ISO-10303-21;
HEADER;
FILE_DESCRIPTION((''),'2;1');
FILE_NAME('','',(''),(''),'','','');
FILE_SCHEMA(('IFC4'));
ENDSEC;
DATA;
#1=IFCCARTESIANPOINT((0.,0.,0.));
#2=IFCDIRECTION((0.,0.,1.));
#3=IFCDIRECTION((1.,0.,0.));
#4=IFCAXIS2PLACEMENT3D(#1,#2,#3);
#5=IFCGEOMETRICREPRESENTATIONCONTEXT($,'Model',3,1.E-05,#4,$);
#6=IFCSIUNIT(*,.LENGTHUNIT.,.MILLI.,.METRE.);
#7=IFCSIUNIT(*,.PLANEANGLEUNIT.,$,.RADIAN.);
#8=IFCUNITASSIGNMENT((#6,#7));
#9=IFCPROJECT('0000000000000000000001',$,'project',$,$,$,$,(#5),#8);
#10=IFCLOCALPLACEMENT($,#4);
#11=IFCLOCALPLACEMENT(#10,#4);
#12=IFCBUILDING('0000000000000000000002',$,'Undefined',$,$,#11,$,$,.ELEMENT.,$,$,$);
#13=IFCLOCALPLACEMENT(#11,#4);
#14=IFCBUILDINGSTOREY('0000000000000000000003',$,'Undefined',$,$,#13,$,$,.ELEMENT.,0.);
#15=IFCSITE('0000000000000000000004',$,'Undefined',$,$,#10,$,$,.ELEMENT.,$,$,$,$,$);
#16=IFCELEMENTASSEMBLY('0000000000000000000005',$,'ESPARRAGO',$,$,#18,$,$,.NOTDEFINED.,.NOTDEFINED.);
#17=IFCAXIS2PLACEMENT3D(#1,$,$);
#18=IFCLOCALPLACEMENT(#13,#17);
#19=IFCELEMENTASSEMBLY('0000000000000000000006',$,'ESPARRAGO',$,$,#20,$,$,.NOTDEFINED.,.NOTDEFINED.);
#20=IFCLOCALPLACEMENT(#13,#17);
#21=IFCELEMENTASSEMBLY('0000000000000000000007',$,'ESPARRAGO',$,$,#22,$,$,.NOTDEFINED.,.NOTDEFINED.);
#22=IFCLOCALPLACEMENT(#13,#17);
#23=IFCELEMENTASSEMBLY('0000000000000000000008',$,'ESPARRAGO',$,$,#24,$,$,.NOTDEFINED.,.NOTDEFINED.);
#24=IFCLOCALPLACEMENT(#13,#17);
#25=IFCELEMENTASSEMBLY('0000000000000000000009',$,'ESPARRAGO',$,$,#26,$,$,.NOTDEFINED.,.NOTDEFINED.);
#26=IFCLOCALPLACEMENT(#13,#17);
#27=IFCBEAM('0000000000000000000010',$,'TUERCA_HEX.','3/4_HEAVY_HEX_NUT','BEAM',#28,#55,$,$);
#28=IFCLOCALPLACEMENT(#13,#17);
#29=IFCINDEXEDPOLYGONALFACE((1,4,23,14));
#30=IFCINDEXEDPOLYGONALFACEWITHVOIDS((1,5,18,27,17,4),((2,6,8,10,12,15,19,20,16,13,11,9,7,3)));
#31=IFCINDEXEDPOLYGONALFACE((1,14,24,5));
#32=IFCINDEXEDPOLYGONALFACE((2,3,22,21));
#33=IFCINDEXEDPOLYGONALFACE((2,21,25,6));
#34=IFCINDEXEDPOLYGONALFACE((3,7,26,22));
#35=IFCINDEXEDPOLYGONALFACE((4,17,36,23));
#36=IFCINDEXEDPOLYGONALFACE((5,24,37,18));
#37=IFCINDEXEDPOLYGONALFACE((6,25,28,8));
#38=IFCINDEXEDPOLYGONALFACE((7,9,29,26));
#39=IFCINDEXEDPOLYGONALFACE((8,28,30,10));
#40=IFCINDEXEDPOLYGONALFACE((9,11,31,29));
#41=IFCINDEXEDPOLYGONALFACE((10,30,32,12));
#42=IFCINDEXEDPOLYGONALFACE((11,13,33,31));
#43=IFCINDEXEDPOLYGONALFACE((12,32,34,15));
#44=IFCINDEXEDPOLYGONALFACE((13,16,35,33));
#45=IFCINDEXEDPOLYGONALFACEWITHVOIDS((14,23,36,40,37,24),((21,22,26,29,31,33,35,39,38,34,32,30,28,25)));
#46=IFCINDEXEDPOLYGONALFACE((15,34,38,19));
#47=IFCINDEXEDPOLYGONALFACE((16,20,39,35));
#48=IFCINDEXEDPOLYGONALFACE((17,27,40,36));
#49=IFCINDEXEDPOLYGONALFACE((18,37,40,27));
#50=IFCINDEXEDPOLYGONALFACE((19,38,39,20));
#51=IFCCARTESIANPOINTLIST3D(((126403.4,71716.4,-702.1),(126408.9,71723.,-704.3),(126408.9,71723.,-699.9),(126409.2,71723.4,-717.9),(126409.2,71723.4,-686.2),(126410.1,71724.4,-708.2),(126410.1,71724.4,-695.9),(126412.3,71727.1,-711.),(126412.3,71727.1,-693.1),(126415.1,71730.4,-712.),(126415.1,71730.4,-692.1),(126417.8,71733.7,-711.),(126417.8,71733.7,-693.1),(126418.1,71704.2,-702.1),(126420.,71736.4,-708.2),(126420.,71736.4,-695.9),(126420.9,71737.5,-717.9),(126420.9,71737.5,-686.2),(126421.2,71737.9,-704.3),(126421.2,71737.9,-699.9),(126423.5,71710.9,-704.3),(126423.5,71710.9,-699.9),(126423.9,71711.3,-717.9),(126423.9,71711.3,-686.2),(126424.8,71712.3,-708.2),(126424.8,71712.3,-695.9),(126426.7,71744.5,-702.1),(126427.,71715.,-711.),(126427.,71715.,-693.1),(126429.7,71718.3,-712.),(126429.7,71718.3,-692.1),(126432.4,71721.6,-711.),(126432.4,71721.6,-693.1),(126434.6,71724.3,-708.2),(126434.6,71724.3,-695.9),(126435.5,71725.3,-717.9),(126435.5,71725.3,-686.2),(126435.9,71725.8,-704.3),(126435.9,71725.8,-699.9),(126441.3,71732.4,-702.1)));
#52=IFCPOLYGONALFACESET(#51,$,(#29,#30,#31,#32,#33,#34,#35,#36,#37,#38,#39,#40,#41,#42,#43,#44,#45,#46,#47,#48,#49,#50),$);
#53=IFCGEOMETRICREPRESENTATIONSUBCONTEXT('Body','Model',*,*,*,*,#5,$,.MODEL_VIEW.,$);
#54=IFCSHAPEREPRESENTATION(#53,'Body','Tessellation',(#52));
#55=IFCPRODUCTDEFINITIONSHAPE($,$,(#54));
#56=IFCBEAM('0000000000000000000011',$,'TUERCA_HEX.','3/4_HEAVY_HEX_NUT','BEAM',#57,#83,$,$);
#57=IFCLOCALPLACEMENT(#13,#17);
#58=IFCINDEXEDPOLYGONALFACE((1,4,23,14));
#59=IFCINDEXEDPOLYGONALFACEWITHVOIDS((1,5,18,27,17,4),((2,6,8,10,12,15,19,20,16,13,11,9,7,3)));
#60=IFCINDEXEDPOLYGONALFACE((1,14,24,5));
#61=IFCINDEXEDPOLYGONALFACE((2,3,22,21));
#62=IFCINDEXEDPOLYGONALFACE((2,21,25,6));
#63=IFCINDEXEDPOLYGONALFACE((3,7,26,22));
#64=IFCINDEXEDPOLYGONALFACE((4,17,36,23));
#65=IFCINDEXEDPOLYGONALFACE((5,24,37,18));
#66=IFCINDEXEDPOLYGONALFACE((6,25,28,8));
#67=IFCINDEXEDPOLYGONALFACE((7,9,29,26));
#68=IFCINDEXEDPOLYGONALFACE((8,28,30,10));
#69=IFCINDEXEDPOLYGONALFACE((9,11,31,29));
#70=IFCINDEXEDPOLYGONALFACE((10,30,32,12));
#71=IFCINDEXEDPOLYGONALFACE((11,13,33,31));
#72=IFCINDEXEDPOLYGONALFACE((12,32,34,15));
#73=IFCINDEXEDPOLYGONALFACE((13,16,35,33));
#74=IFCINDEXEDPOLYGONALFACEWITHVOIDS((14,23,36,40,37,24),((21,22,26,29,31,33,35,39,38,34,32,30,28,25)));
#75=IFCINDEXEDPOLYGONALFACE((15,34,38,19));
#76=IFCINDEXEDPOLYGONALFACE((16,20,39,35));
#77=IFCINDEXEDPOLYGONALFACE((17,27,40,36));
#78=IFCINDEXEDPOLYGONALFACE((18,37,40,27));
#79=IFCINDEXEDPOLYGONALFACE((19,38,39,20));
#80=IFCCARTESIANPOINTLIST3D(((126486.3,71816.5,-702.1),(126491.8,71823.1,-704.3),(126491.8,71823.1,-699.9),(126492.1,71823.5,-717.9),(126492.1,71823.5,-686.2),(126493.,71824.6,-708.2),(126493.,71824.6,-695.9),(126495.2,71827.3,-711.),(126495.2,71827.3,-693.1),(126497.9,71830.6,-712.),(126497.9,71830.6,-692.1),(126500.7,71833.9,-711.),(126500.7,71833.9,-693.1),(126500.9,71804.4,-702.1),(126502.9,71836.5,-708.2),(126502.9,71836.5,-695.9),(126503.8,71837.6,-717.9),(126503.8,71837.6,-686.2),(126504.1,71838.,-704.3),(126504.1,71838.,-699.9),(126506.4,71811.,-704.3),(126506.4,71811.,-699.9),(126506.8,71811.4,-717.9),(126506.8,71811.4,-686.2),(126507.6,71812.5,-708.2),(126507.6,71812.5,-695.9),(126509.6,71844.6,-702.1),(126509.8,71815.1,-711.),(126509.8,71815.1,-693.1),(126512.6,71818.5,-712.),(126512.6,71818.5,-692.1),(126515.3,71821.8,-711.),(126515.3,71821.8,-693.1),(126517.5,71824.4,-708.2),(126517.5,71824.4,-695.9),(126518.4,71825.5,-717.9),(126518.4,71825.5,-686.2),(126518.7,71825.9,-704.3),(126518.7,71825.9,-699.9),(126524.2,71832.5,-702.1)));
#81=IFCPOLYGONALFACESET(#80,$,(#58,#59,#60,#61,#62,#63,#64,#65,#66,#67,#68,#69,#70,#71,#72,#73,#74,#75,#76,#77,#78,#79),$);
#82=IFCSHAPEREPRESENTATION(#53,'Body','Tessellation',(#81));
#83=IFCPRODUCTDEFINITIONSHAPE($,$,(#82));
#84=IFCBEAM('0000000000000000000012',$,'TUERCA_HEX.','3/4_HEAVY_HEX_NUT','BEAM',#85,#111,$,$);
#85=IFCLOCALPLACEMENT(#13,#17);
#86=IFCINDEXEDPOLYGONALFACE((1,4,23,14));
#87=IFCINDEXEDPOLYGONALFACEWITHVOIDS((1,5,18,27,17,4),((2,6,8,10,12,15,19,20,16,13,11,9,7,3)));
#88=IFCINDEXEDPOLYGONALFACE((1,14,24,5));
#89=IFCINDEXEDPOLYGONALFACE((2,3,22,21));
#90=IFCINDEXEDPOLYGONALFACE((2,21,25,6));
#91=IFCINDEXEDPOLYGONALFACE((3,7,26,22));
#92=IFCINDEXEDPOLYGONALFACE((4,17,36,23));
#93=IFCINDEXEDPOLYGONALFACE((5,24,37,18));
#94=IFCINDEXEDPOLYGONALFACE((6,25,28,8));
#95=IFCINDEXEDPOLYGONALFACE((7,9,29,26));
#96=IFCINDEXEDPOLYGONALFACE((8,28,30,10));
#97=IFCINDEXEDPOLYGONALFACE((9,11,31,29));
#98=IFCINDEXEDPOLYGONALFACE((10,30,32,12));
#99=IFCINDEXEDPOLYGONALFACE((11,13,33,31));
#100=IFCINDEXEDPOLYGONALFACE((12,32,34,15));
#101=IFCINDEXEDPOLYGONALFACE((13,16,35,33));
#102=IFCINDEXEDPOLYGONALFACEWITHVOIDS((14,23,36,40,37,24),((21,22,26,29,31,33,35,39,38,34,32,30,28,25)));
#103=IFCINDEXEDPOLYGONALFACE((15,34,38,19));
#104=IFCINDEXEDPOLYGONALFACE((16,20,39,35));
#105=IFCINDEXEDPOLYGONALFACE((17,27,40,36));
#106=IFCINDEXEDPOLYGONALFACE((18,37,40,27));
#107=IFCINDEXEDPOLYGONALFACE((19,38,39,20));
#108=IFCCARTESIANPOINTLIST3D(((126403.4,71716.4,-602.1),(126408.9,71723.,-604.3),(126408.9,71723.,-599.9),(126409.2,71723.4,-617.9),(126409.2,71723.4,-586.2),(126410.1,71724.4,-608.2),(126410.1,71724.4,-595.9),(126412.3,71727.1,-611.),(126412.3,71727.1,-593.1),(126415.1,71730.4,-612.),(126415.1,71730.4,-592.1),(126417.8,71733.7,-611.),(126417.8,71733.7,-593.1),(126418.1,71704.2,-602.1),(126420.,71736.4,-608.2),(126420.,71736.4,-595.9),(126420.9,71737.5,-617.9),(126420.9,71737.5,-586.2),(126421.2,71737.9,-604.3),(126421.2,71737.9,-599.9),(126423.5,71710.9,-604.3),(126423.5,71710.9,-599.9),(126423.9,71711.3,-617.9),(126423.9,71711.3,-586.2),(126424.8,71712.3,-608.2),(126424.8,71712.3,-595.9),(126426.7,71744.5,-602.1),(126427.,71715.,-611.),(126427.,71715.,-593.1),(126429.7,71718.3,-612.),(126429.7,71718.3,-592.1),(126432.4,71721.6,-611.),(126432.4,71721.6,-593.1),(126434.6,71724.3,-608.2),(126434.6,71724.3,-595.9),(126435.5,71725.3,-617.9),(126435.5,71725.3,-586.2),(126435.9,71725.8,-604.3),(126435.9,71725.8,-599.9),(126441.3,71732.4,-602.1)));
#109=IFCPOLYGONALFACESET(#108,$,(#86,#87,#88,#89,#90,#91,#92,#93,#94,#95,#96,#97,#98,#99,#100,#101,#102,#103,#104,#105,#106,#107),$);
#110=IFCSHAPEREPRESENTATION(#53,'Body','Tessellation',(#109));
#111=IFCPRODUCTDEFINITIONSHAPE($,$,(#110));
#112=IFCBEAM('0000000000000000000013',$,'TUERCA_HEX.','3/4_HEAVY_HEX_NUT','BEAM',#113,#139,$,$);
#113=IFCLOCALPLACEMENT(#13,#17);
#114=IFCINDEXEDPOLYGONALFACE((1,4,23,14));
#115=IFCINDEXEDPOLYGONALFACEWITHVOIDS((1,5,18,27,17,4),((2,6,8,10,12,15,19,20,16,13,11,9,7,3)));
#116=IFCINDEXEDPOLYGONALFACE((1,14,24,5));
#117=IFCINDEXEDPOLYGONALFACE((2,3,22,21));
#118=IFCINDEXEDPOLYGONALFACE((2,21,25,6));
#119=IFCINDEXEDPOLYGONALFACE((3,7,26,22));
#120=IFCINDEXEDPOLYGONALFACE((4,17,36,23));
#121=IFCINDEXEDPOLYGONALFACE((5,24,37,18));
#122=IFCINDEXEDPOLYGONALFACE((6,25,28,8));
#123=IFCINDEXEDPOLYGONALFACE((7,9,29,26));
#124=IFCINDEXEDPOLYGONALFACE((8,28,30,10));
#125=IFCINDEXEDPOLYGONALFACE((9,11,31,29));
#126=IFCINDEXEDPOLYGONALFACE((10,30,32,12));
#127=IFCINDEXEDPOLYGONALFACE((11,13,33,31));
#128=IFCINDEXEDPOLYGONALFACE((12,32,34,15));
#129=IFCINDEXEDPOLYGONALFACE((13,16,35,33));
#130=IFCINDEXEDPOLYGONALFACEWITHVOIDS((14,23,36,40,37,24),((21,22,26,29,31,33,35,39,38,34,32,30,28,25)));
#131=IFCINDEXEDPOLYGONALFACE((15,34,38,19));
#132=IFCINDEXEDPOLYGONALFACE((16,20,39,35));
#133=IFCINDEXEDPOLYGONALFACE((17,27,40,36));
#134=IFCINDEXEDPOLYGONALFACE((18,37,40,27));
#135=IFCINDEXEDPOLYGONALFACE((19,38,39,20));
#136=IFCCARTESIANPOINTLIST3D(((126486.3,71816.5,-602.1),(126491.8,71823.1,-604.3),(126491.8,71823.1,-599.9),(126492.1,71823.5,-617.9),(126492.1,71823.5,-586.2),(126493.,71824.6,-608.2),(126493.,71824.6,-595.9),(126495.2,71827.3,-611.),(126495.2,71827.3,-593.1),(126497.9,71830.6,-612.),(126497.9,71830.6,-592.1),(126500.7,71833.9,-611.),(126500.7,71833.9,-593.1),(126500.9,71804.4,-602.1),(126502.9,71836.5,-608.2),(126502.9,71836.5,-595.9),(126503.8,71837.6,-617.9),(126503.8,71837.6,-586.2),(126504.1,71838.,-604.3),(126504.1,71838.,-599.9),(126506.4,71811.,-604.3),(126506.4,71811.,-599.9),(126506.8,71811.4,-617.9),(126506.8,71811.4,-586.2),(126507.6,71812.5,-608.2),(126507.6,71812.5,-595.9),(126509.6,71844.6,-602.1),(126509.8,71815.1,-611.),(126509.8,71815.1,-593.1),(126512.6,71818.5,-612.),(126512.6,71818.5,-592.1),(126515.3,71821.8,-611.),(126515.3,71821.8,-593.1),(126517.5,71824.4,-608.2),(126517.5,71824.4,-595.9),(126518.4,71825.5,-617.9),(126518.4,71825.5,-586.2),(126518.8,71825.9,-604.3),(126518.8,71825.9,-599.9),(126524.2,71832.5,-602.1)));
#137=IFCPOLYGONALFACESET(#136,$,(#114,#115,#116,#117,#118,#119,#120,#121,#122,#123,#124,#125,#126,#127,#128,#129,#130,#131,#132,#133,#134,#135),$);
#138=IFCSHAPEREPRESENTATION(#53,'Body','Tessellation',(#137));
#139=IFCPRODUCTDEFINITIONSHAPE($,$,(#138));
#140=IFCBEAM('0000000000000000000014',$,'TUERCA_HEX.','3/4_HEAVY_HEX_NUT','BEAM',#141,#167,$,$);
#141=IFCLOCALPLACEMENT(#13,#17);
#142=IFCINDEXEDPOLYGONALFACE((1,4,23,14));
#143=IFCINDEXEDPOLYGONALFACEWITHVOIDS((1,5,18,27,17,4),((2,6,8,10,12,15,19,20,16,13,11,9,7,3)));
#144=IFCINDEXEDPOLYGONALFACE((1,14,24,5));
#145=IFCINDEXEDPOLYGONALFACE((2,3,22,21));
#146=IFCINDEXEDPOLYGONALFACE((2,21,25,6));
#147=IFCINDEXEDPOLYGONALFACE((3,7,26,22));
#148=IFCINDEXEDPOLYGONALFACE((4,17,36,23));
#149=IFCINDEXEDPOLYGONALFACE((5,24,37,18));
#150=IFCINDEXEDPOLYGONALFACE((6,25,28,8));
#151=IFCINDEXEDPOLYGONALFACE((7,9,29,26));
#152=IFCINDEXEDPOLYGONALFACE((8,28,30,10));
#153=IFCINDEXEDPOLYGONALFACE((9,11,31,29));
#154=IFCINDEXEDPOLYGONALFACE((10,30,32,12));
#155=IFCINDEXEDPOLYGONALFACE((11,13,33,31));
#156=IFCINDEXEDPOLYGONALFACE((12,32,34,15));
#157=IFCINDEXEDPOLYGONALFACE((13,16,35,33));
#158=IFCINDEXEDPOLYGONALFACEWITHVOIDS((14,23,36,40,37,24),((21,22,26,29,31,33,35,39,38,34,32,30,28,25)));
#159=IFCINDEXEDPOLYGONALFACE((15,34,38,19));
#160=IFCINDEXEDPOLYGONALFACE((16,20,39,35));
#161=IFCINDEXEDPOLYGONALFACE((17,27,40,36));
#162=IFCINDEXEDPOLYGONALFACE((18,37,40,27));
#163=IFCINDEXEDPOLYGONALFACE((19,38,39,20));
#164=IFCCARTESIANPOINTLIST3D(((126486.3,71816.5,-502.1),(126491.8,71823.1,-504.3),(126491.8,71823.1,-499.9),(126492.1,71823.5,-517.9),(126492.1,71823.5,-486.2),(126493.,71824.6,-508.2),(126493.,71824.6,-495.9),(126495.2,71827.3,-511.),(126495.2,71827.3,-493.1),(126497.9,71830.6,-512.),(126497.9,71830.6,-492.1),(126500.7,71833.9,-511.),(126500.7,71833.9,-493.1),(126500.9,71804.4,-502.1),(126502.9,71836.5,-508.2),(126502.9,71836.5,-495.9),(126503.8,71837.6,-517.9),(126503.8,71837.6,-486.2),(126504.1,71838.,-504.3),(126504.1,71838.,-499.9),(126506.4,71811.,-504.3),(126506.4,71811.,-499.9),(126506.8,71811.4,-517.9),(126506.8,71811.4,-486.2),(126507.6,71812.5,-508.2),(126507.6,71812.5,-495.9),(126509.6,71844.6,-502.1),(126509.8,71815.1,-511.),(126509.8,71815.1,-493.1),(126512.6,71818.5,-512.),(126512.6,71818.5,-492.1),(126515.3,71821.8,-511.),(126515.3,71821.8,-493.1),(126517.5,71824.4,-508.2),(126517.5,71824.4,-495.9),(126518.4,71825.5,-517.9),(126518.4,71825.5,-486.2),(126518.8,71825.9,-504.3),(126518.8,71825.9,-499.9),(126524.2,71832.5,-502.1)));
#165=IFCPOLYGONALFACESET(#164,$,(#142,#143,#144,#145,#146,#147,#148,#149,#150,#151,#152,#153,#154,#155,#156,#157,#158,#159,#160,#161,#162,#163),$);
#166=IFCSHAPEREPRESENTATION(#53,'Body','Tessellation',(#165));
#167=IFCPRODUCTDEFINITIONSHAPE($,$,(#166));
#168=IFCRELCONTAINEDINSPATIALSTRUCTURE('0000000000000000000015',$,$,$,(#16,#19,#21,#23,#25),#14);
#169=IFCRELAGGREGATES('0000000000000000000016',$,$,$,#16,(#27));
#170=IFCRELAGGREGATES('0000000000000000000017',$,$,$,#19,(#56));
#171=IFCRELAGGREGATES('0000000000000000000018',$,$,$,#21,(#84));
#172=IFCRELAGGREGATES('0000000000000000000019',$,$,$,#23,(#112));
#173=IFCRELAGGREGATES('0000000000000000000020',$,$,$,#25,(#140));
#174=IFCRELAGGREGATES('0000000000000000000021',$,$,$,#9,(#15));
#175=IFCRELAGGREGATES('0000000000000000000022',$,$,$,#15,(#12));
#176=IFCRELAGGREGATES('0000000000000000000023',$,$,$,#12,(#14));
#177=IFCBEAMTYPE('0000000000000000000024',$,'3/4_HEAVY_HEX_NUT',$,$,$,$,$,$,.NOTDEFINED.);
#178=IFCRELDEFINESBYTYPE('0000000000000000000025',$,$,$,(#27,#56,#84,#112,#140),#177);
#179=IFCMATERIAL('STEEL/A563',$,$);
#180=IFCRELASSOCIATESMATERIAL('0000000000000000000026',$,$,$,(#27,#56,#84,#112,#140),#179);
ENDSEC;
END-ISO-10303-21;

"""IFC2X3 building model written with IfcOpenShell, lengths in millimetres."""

from ifc_helpers import new_model, si_unit, frame, origin_with_axes, place, context, subcontext, project, spatial, polyline, outline, extrude, material, type_object, element, aggregate, save


model = new_model("IFC2X3")

# Units and contexts
model_context = context("Model", 3, precision=1e-05, world=origin_with_axes())
body_context = subcontext(model_context, "Body", "Model", "MODEL_VIEW")
ifc_project = project(units=[si_unit("LENGTHUNIT", "METRE", prefix="MILLI"), si_unit("PLANEANGLEUNIT", "RADIAN")], contexts=[model_context])

# Site, building, storey
site_placement = place(None, origin_with_axes())
site = spatial("IfcSite", under=ifc_project, at=site_placement, Name="Undefined", CompositionType="ELEMENT")
building_placement = place(site_placement, origin_with_axes())
building = spatial("IfcBuilding", under=site, at=building_placement, Name="Undefined", CompositionType="ELEMENT")
storey_placement = place(building_placement, origin_with_axes())
storey = spatial("IfcBuildingStorey", under=building, at=storey_placement, Name="Undefined", CompositionType="ELEMENT", Elevation=0.0)

# Element assemblies
assembly_1_placement = place(storey_placement, origin_with_axes())
assembly_1 = element("IfcElementAssembly", 1, at=assembly_1_placement, inside=storey, Name="ESPARRAGO", AssemblyPlace="NOTDEFINED", PredefinedType="NOTDEFINED")
assembly_2_placement = place(storey_placement, origin_with_axes())
assembly_2 = element("IfcElementAssembly", 2, at=assembly_2_placement, inside=storey, Name="ESPARRAGO", AssemblyPlace="NOTDEFINED", PredefinedType="NOTDEFINED")
assembly_3_placement = place(storey_placement, origin_with_axes())
assembly_3 = element("IfcElementAssembly", 3, at=assembly_3_placement, inside=storey, Name="ESPARRAGO", AssemblyPlace="NOTDEFINED", PredefinedType="NOTDEFINED")
assembly_4_placement = place(storey_placement, origin_with_axes())
assembly_4 = element("IfcElementAssembly", 4, at=assembly_4_placement, inside=storey, Name="ESPARRAGO", AssemblyPlace="NOTDEFINED", PredefinedType="NOTDEFINED")
assembly_5_placement = place(storey_placement, origin_with_axes())
assembly_5 = element("IfcElementAssembly", 5, at=assembly_5_placement, inside=storey, Name="ESPARRAGO", AssemblyPlace="NOTDEFINED", PredefinedType="NOTDEFINED")

# Beams
ifc_material_1 = material(Name="STEEL/A563")
beam_type_1 = type_object("IfcBeamType", Name="3/4_HEAVY_HEX_NUT", PredefinedType="NOTDEFINED")
beam_1_placement = place(assembly_1_placement, frame((126415.1, 71730.4, -702.1), z_axis=(0.000012, -0.00001, 1.0), x_axis=(0.7704, -0.637561, -0.000016)))
beam_1 = element("IfcBeam", 6, at=beam_1_placement, type_object=beam_type_1, material=ifc_material_1, Name="TUERCA_HEX.", Description="3/4_HEAVY_HEX_NUT", ObjectType="BEAM", context=body_context, shape_type="SweptSolid", body=[
    extrude(outline(polyline([(9.1, -15.8), (-9.1, -15.8), (-18.3, 0.0), (-9.1, 15.8), (9.1, 15.8), (18.3, 0.0), (9.1, -15.8)]), holes=[polyline([(-4.3, 8.9), (-7.8, 6.2), (-9.7, 2.2), (-9.7, -2.2), (-7.8, -6.2), (-4.3, -8.9), (0.0, -9.9), (4.3, -8.9), (7.8, -6.2), (9.7, -2.2), (9.7, 2.2), (7.8, 6.2), (4.3, 8.9), (0.0, 9.9), (-4.3, 8.9)])]), frame((19.0, 0.0, 0.0), z_axis=(-1.0, 0.0, 0.0), x_axis=(0.0, -1.0, 0.0)), (0.0, 0.0, 1.0), 19.0),
])
beam_2_placement = place(assembly_2_placement, frame((126497.9, 71830.6, -702.1), z_axis=(0.000012, -0.00001, 1.0), x_axis=(0.7704, -0.637561, -0.000016)))
beam_2 = element("IfcBeam", 7, at=beam_2_placement, type_object=beam_type_1, material=ifc_material_1, Name="TUERCA_HEX.", Description="3/4_HEAVY_HEX_NUT", ObjectType="BEAM", context=body_context, shape_type="SweptSolid", body=[
    extrude(outline(polyline([(9.1, -15.8), (-9.1, -15.8), (-18.3, 0.0), (-9.1, 15.8), (9.1, 15.8), (18.3, 0.0), (9.1, -15.8)]), holes=[polyline([(-4.3, 8.9), (-7.8, 6.2), (-9.7, 2.2), (-9.7, -2.2), (-7.8, -6.2), (-4.3, -8.9), (0.0, -9.9), (4.3, -8.9), (7.8, -6.2), (9.7, -2.2), (9.7, 2.2), (7.8, 6.2), (4.3, 8.9), (0.0, 9.9), (-4.3, 8.9)])]), frame((19.0, 0.0, 0.0), z_axis=(-1.0, 0.0, 0.0), x_axis=(0.0, -1.0, 0.0)), (0.0, 0.0, 1.0), 19.0),
])
beam_3_placement = place(assembly_3_placement, frame((126415.1, 71730.4, -602.1), z_axis=(0.000012, -0.00001, 1.0), x_axis=(0.7704, -0.637561, -0.000016)))
beam_3 = element("IfcBeam", 8, at=beam_3_placement, type_object=beam_type_1, material=ifc_material_1, Name="TUERCA_HEX.", Description="3/4_HEAVY_HEX_NUT", ObjectType="BEAM", context=body_context, shape_type="SweptSolid", body=[
    extrude(outline(polyline([(9.1, -15.8), (-9.1, -15.8), (-18.3, 0.0), (-9.1, 15.8), (9.1, 15.8), (18.3, 0.0), (9.1, -15.8)]), holes=[polyline([(-4.3, 8.9), (-7.8, 6.2), (-9.7, 2.2), (-9.7, -2.2), (-7.8, -6.2), (-4.3, -8.9), (0.0, -9.9), (4.3, -8.9), (7.8, -6.2), (9.7, -2.2), (9.7, 2.2), (7.8, 6.2), (4.3, 8.9), (0.0, 9.9), (-4.3, 8.9)])]), frame((19.0, 0.0, 0.0), z_axis=(-1.0, 0.0, 0.0), x_axis=(0.0, -1.0, 0.0)), (0.0, 0.0, 1.0), 19.0),
])
beam_4_placement = place(assembly_4_placement, frame((126497.9, 71830.6, -602.1), z_axis=(0.000012, -0.00001, 1.0), x_axis=(0.7704, -0.637561, -0.000016)))
beam_4 = element("IfcBeam", 9, at=beam_4_placement, type_object=beam_type_1, material=ifc_material_1, Name="TUERCA_HEX.", Description="3/4_HEAVY_HEX_NUT", ObjectType="BEAM", context=body_context, shape_type="SweptSolid", body=[
    extrude(outline(polyline([(9.1, -15.8), (-9.1, -15.8), (-18.3, 0.0), (-9.1, 15.8), (9.1, 15.8), (18.3, 0.0), (9.1, -15.8)]), holes=[polyline([(-4.3, 8.9), (-7.8, 6.2), (-9.7, 2.2), (-9.7, -2.2), (-7.8, -6.2), (-4.3, -8.9), (0.0, -9.9), (4.3, -8.9), (7.8, -6.2), (9.7, -2.2), (9.7, 2.2), (7.8, 6.2), (4.3, 8.9), (0.0, 9.9), (-4.3, 8.9)])]), frame((19.0, 0.0, 0.0), z_axis=(-1.0, 0.0, 0.0), x_axis=(0.0, -1.0, 0.0)), (0.0, 0.0, 1.0), 19.0),
])
beam_5_placement = place(assembly_5_placement, frame((126497.9, 71830.6, -502.1), z_axis=(0.000012, -0.00001, 1.0), x_axis=(0.7704, -0.637561, -0.000016)))
beam_5 = element("IfcBeam", 10, at=beam_5_placement, type_object=beam_type_1, material=ifc_material_1, Name="TUERCA_HEX.", Description="3/4_HEAVY_HEX_NUT", ObjectType="BEAM", context=body_context, shape_type="SweptSolid", body=[
    extrude(outline(polyline([(9.1, -15.8), (-9.1, -15.8), (-18.3, 0.0), (-9.1, 15.8), (9.1, 15.8), (18.3, 0.0), (9.1, -15.8)]), holes=[polyline([(-4.3, 8.9), (-7.8, 6.2), (-9.7, 2.2), (-9.7, -2.2), (-7.8, -6.2), (-4.3, -8.9), (0.0, -9.9), (4.3, -8.9), (7.8, -6.2), (9.7, -2.2), (9.7, 2.2), (7.8, 6.2), (4.3, 8.9), (0.0, 9.9), (-4.3, 8.9)])]), frame((19.0, 0.0, 0.0), z_axis=(-1.0, 0.0, 0.0), x_axis=(0.0, -1.0, 0.0)), (0.0, 0.0, 1.0), 19.0),
])
aggregate(assembly_1, [beam_1])
aggregate(assembly_2, [beam_2])
aggregate(assembly_3, [beam_3])
aggregate(assembly_4, [beam_4])
aggregate(assembly_5, [beam_5])

save(model, "model.ifc")
